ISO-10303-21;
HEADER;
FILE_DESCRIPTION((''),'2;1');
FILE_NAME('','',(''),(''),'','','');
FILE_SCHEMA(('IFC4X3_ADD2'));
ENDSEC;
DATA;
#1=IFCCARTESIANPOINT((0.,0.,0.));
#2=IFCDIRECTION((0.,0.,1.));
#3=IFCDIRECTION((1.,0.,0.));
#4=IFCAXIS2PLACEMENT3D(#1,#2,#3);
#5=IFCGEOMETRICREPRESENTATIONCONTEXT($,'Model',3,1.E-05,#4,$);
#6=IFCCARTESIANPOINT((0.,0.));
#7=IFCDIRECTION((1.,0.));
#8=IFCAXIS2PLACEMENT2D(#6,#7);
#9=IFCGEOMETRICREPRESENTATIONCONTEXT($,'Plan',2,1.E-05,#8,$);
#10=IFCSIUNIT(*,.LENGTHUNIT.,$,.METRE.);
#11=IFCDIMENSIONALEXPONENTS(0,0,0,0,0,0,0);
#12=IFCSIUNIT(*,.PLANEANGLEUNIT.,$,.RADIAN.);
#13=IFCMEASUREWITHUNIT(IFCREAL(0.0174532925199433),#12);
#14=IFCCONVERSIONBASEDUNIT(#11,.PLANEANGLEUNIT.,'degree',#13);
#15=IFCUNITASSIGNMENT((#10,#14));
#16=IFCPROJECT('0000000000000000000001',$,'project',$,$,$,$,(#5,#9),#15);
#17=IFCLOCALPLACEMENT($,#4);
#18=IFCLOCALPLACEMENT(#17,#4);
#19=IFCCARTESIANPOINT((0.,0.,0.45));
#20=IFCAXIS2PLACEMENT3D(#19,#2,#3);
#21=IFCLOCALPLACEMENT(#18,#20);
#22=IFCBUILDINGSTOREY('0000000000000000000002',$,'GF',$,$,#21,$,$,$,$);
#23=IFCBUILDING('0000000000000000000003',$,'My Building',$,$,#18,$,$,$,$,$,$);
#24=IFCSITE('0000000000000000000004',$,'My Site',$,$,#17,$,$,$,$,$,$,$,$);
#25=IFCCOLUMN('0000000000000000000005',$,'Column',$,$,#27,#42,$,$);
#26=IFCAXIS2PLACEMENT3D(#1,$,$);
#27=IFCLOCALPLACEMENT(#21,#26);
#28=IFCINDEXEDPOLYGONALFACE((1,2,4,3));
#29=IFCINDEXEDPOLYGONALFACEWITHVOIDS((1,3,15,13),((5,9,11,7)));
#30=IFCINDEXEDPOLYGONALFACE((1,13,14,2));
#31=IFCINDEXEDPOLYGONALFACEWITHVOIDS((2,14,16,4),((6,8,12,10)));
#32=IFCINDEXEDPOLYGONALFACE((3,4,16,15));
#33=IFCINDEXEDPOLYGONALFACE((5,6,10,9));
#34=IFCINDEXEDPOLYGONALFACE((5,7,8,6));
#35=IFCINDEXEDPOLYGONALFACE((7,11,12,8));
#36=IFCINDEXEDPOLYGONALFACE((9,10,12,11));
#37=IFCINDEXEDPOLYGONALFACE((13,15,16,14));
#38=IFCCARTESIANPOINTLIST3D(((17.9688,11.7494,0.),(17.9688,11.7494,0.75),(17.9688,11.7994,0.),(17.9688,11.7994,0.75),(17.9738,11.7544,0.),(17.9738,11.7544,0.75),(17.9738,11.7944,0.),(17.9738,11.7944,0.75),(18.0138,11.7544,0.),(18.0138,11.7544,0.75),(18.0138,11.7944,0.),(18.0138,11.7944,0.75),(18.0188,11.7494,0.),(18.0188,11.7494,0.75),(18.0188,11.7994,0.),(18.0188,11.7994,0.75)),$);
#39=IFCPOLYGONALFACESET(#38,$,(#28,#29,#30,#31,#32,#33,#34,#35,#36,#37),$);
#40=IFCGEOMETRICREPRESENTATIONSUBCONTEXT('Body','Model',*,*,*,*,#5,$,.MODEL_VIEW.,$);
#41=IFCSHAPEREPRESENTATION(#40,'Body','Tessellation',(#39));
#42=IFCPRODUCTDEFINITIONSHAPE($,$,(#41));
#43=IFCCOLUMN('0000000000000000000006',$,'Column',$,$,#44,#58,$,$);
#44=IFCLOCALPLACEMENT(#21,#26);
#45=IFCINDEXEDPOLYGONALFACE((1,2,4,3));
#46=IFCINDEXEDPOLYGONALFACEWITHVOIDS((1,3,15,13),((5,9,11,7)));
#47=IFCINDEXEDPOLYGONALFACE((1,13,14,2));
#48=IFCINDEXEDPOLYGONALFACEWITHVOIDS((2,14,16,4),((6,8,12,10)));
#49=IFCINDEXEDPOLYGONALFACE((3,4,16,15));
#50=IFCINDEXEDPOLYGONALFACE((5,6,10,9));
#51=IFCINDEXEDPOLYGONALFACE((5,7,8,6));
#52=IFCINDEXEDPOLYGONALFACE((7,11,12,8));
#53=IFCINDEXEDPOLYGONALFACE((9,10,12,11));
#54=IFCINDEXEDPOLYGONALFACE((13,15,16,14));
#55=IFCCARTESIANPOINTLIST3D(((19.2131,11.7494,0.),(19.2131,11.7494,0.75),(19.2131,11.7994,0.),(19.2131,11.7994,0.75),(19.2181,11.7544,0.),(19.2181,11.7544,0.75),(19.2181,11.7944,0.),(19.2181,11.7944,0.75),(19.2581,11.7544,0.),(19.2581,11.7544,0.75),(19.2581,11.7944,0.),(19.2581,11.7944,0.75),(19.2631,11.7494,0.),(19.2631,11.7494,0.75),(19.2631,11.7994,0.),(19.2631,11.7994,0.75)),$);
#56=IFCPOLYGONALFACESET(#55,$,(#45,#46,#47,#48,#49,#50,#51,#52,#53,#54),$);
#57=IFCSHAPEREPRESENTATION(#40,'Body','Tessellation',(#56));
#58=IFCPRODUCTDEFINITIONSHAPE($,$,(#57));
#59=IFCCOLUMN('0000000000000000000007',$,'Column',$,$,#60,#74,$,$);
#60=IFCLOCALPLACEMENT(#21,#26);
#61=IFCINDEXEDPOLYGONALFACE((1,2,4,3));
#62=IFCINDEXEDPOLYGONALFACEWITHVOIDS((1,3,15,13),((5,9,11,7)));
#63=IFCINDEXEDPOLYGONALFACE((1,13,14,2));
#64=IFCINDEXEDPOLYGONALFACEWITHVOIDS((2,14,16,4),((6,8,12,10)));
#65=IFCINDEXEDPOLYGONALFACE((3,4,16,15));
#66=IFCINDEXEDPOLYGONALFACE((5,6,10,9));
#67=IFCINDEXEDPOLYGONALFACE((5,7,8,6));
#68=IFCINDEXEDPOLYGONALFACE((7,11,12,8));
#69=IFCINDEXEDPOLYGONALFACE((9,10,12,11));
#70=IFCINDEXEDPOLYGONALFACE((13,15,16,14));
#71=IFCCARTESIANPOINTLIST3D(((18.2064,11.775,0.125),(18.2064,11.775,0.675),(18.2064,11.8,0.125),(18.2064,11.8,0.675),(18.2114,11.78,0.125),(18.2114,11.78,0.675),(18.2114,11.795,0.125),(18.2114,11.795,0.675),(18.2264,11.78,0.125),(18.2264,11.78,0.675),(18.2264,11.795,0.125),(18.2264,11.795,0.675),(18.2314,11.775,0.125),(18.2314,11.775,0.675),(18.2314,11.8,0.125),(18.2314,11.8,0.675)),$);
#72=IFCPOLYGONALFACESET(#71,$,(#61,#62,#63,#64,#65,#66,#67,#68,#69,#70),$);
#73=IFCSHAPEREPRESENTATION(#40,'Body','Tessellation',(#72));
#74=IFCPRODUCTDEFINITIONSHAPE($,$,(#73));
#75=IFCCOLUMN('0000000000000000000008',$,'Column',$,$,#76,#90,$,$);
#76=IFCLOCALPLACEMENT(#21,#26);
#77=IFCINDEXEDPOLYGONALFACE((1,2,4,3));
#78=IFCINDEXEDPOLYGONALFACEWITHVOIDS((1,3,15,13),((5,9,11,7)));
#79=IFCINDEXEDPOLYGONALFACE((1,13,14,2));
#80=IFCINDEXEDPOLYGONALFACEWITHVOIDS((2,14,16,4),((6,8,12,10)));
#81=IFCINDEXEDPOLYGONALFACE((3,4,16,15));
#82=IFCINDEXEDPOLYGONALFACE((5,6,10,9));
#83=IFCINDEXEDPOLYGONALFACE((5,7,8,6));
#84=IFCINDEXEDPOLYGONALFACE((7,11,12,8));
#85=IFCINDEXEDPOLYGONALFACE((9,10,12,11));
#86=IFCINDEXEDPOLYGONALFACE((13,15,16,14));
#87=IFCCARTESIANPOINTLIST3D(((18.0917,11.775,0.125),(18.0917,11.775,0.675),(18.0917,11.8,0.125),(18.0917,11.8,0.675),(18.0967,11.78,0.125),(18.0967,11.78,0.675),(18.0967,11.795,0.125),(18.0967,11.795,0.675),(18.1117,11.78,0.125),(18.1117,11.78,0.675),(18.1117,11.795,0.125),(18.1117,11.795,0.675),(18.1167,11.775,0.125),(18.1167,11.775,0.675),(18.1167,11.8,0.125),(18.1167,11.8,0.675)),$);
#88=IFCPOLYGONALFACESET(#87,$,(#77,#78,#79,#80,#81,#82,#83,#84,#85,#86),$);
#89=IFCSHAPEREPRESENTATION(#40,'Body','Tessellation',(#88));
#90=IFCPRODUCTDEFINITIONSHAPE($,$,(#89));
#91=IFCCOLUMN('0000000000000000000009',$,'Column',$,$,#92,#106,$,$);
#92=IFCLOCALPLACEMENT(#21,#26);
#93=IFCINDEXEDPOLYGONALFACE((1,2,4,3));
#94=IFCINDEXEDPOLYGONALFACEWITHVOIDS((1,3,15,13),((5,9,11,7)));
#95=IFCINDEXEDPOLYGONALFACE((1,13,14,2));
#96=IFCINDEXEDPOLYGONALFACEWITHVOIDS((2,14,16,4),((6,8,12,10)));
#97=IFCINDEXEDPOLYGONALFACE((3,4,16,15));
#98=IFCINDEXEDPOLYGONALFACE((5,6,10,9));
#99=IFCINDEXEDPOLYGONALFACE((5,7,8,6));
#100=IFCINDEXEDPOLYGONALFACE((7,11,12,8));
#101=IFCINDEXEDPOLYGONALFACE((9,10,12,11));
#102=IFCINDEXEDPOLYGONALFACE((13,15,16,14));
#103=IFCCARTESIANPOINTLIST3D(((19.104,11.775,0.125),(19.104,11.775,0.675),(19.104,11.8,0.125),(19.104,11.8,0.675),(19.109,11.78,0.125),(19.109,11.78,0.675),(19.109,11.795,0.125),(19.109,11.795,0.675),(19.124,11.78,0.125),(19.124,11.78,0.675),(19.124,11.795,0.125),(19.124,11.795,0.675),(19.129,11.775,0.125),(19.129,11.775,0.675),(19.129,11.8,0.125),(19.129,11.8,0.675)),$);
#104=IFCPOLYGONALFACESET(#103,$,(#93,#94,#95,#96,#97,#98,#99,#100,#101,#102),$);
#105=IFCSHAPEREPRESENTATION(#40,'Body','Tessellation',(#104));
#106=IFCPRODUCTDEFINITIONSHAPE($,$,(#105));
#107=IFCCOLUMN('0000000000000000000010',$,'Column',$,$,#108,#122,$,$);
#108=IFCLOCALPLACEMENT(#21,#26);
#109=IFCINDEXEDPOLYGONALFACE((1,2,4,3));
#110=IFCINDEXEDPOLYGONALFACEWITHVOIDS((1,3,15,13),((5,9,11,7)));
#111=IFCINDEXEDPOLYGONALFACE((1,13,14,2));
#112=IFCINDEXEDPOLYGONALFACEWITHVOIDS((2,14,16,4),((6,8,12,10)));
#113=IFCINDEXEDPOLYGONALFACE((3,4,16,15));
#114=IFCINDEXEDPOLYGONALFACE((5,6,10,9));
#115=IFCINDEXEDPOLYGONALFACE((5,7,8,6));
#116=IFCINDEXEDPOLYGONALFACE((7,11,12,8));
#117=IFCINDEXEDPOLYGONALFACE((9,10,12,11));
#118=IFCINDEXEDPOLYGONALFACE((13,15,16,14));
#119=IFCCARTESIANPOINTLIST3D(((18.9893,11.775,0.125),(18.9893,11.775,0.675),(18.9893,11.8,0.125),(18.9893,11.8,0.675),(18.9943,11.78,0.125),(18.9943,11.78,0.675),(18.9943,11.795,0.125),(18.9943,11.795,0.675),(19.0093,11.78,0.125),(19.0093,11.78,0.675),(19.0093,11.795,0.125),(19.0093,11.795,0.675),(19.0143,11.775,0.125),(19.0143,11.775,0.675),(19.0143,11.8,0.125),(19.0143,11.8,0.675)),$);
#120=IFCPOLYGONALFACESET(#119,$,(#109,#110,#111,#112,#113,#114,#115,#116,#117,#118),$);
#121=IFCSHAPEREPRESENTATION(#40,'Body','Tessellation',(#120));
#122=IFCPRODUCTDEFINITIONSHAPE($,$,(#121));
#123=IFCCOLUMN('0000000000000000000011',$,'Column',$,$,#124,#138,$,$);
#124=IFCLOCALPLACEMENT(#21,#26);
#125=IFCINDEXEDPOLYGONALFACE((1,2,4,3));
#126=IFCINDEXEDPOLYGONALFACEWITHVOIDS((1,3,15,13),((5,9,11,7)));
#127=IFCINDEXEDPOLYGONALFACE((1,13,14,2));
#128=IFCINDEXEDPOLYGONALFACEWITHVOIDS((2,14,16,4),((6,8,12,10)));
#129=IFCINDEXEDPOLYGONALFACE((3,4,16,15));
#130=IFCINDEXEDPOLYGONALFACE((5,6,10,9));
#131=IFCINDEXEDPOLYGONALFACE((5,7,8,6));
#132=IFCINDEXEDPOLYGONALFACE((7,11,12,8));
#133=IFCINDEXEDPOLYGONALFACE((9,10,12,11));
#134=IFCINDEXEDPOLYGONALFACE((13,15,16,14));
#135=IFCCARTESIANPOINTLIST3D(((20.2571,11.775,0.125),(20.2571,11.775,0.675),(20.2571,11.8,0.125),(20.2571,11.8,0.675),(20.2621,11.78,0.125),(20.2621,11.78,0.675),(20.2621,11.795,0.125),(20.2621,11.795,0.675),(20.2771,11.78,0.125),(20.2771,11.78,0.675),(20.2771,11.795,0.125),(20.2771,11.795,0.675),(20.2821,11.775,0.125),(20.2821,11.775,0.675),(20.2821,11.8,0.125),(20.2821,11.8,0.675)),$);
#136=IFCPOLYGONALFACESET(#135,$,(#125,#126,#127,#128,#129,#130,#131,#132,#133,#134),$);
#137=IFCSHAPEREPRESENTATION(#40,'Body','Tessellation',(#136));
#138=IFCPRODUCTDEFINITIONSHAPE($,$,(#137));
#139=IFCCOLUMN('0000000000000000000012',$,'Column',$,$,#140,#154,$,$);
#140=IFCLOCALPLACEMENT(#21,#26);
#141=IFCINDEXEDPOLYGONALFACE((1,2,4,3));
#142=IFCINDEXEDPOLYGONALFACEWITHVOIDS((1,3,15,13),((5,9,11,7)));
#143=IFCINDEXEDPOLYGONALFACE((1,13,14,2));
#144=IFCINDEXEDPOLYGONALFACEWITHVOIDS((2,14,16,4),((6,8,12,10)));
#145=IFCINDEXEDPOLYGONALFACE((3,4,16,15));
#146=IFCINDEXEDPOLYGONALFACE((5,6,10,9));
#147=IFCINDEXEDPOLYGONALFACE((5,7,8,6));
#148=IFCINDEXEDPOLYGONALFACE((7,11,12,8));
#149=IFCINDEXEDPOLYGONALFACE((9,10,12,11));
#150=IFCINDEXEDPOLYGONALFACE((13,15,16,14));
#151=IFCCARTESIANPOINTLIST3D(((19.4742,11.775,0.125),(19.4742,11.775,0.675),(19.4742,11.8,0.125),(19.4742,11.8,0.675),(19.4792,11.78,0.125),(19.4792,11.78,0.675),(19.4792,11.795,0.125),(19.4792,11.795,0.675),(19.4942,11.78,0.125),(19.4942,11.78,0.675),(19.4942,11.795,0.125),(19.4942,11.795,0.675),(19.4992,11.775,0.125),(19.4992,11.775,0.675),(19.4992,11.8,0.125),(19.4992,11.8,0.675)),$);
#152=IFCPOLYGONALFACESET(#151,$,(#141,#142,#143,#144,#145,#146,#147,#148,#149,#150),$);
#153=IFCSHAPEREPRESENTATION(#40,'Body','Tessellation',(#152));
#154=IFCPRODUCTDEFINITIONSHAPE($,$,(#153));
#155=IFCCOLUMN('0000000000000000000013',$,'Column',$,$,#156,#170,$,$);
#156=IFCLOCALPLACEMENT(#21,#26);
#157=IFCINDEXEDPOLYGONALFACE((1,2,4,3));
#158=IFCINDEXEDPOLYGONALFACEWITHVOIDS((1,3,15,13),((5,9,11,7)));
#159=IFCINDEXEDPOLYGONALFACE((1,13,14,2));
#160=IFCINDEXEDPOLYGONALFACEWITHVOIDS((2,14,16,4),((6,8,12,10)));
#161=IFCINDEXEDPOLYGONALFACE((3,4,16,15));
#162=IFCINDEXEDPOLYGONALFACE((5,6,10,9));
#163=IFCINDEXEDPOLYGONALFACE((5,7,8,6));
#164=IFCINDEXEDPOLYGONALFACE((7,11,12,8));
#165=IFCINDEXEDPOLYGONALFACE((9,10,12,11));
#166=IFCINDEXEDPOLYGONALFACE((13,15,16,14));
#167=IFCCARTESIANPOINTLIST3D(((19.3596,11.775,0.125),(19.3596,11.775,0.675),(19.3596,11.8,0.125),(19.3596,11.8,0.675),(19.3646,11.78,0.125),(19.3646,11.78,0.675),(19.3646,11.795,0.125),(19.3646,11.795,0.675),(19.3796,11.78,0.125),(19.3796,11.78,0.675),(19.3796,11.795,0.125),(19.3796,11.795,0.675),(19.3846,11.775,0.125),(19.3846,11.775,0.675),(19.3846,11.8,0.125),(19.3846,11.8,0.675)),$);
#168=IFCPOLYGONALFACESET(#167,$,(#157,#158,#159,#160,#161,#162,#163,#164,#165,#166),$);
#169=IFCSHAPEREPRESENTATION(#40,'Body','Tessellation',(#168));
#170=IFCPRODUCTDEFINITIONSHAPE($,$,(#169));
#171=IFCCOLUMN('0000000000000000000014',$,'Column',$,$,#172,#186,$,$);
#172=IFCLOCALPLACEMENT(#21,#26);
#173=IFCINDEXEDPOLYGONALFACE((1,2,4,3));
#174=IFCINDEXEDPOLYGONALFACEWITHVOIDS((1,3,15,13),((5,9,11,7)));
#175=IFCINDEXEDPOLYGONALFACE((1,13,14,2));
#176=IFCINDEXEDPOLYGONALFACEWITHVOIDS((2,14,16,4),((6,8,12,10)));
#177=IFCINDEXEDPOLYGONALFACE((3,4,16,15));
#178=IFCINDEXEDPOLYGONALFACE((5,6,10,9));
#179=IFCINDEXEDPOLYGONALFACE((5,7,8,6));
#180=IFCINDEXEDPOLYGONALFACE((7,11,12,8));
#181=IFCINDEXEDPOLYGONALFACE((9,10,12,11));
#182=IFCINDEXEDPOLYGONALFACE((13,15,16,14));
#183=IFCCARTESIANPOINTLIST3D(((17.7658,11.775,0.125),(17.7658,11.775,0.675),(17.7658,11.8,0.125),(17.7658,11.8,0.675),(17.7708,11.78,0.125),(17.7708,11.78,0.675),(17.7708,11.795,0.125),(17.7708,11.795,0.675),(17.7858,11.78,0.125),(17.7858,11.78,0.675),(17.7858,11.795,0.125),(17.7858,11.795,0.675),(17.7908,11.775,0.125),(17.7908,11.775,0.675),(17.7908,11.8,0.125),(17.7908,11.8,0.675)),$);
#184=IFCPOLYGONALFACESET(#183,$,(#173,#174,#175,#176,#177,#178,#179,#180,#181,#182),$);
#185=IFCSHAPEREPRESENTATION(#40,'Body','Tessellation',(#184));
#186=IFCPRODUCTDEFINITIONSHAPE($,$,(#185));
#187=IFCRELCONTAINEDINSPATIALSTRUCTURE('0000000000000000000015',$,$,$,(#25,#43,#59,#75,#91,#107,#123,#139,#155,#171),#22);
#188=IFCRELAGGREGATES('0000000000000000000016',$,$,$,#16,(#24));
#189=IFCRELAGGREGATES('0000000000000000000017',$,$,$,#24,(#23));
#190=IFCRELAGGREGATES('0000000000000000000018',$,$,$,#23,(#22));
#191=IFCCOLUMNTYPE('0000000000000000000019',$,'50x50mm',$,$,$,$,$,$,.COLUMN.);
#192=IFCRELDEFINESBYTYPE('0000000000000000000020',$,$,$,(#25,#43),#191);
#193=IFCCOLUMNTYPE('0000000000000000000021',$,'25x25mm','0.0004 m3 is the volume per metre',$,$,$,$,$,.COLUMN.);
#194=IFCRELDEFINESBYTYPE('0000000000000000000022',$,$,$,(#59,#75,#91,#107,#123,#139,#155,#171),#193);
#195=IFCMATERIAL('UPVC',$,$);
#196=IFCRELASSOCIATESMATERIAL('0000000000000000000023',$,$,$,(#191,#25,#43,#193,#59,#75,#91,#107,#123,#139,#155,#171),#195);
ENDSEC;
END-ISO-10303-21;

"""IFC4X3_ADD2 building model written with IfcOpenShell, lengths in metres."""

from ifc_helpers import new_model, entity, si_unit, converted_unit, frame, origin_with_axes, origin_2d_with_axis, place, context, subcontext, project, spatial, hollow_rectangle, extrude, material, material_profile, profile_set, profile_usage, type_object, element, save


model = new_model("IFC4X3_ADD2")

# Units and contexts
model_context = context("Model", 3, precision=1e-05, world=origin_with_axes())
plan_context = context("Plan", 2, precision=1e-05, world=origin_2d_with_axis())
body_context = subcontext(model_context, "Body", "Model", "MODEL_VIEW")
ifc_project = project(units=[si_unit("LENGTHUNIT", "METRE"), converted_unit("PLANEANGLEUNIT", "degree", entity("IfcReal", 0.0174532925199433), si_unit("PLANEANGLEUNIT", "RADIAN"), dimensions=[0, 0, 0, 0, 0, 0, 0])], contexts=[model_context, plan_context])

# Site, building, storey
site_placement = place(None, origin_with_axes())
site = spatial("IfcSite", under=ifc_project, at=site_placement, Name="My Site")
building_placement = place(site_placement, origin_with_axes())
building = spatial("IfcBuilding", under=site, at=building_placement, Name="My Building")
storey_placement = place(building_placement, frame((0.0, 0.0, 0.45), z_axis=(0.0, 0.0, 1.0), x_axis=(1.0, 0.0, 0.0)))
storey = spatial("IfcBuildingStorey", under=building, at=storey_placement, Name="GF")

# Columns
ifc_material_1 = material(Name="UPVC")
ifc_material_profile_1 = material_profile(ifc_material_1, hollow_rectangle(XDim=0.05, YDim=0.05, WallThickness=0.005))
ifc_profile_set_1 = profile_set([ifc_material_profile_1])
ifc_profile_usage_1 = profile_usage(ifc_profile_set_1)
column_type_1 = type_object("IfcColumnType", Name="50x50mm", PredefinedType="COLUMN", material=ifc_profile_set_1)
column_1_placement = place(storey_placement, frame((17.9938, 11.7744, 0.0), z_axis=(0.0, 0.0, 1.0), x_axis=(1.0, 0.0, 0.0)))
element("IfcColumn", 1, at=column_1_placement, inside=storey, type_object=column_type_1, material=ifc_profile_usage_1, Name="Column", context=body_context, shape_type="SweptSolid", body=[
    extrude(hollow_rectangle(XDim=0.05, YDim=0.05, WallThickness=0.005), origin_with_axes(), (0.0, 0.0, 1.0), 0.75),
])
ifc_profile_usage_2 = profile_usage(ifc_profile_set_1)
column_2_placement = place(storey_placement, frame((19.2381, 11.7744, 0.0), z_axis=(0.0, 0.0, 1.0), x_axis=(1.0, 0.0, 0.0)))
element("IfcColumn", 2, at=column_2_placement, inside=storey, type_object=column_type_1, material=ifc_profile_usage_2, Name="Column", context=body_context, shape_type="SweptSolid", body=[
    extrude(hollow_rectangle(XDim=0.05, YDim=0.05, WallThickness=0.005), origin_with_axes(), (0.0, 0.0, 1.0), 0.75),
])
ifc_material_profile_2 = material_profile(ifc_material_1, hollow_rectangle(XDim=0.025, YDim=0.025, WallThickness=0.005))
ifc_profile_set_2 = profile_set([ifc_material_profile_2])
ifc_profile_usage_3 = profile_usage(ifc_profile_set_2, cardinal=5)
column_type_2 = type_object("IfcColumnType", Name="25x25mm", Description="0.0004 m3 is the volume per metre", PredefinedType="COLUMN", material=ifc_profile_set_2)
column_3_placement = place(storey_placement, frame((18.2189, 11.7875, 0.125), z_axis=(0.0, 0.0, 1.0), x_axis=(1.0, 0.0, 0.0)))
element("IfcColumn", 3, at=column_3_placement, inside=storey, type_object=column_type_2, material=ifc_profile_usage_3, Name="Column", context=body_context, shape_type="SweptSolid", body=[
    extrude(hollow_rectangle(XDim=0.025, YDim=0.025, WallThickness=0.005), origin_with_axes(), (0.0, 0.0, 1.0), 0.55),
])
ifc_profile_usage_4 = profile_usage(ifc_profile_set_2, cardinal=5)
column_4_placement = place(storey_placement, frame((18.1042, 11.7875, 0.125), z_axis=(0.0, 0.0, 1.0), x_axis=(1.0, 0.0, 0.0)))
element("IfcColumn", 4, at=column_4_placement, inside=storey, type_object=column_type_2, material=ifc_profile_usage_4, Name="Column", context=body_context, shape_type="SweptSolid", body=[
    extrude(hollow_rectangle(XDim=0.025, YDim=0.025, WallThickness=0.005), origin_with_axes(), (0.0, 0.0, 1.0), 0.55),
])
ifc_profile_usage_5 = profile_usage(ifc_profile_set_2, cardinal=5)
column_5_placement = place(storey_placement, frame((19.1165, 11.7875, 0.125), z_axis=(0.0, 0.0, 1.0), x_axis=(1.0, 0.0, 0.0)))
element("IfcColumn", 5, at=column_5_placement, inside=storey, type_object=column_type_2, material=ifc_profile_usage_5, Name="Column", context=body_context, shape_type="SweptSolid", body=[
    extrude(hollow_rectangle(XDim=0.025, YDim=0.025, WallThickness=0.005), origin_with_axes(), (0.0, 0.0, 1.0), 0.55),
])
ifc_profile_usage_6 = profile_usage(ifc_profile_set_2, cardinal=5)
column_6_placement = place(storey_placement, frame((19.0018, 11.7875, 0.125), z_axis=(0.0, 0.0, 1.0), x_axis=(1.0, 0.0, 0.0)))
element("IfcColumn", 6, at=column_6_placement, inside=storey, type_object=column_type_2, material=ifc_profile_usage_6, Name="Column", context=body_context, shape_type="SweptSolid", body=[
    extrude(hollow_rectangle(XDim=0.025, YDim=0.025, WallThickness=0.005), origin_with_axes(), (0.0, 0.0, 1.0), 0.55),
])
ifc_profile_usage_7 = profile_usage(ifc_profile_set_2, cardinal=5)
column_7_placement = place(storey_placement, frame((20.2696, 11.7875, 0.125), z_axis=(0.0, 0.0, 1.0), x_axis=(1.0, 0.0, 0.0)))
element("IfcColumn", 7, at=column_7_placement, inside=storey, type_object=column_type_2, material=ifc_profile_usage_7, Name="Column", context=body_context, shape_type="SweptSolid", body=[
    extrude(hollow_rectangle(XDim=0.025, YDim=0.025, WallThickness=0.005), origin_with_axes(), (0.0, 0.0, 1.0), 0.55),
])
ifc_profile_usage_8 = profile_usage(ifc_profile_set_2, cardinal=5)
column_8_placement = place(storey_placement, frame((19.4867, 11.7875, 0.125), z_axis=(0.0, 0.0, 1.0), x_axis=(1.0, 0.0, 0.0)))
element("IfcColumn", 8, at=column_8_placement, inside=storey, type_object=column_type_2, material=ifc_profile_usage_8, Name="Column", context=body_context, shape_type="SweptSolid", body=[
    extrude(hollow_rectangle(XDim=0.025, YDim=0.025, WallThickness=0.005), origin_with_axes(), (0.0, 0.0, 1.0), 0.55),
])
ifc_profile_usage_9 = profile_usage(ifc_profile_set_2, cardinal=5)
column_9_placement = place(storey_placement, frame((19.3721, 11.7875, 0.125), z_axis=(0.0, 0.0, 1.0), x_axis=(1.0, 0.0, 0.0)))
element("IfcColumn", 9, at=column_9_placement, inside=storey, type_object=column_type_2, material=ifc_profile_usage_9, Name="Column", context=body_context, shape_type="SweptSolid", body=[
    extrude(hollow_rectangle(XDim=0.025, YDim=0.025, WallThickness=0.005), origin_with_axes(), (0.0, 0.0, 1.0), 0.55),
])
ifc_profile_usage_10 = profile_usage(ifc_profile_set_2, cardinal=5)
column_10_placement = place(storey_placement, frame((17.7783, 11.7875, 0.125), z_axis=(0.0, 0.0, 1.0), x_axis=(1.0, 0.0, 0.0)))
element("IfcColumn", 10, at=column_10_placement, inside=storey, type_object=column_type_2, material=ifc_profile_usage_10, Name="Column", context=body_context, shape_type="SweptSolid", body=[
    extrude(hollow_rectangle(XDim=0.025, YDim=0.025, WallThickness=0.005), origin_with_axes(), (0.0, 0.0, 1.0), 0.55),
])

save(model, "model.ifc")
